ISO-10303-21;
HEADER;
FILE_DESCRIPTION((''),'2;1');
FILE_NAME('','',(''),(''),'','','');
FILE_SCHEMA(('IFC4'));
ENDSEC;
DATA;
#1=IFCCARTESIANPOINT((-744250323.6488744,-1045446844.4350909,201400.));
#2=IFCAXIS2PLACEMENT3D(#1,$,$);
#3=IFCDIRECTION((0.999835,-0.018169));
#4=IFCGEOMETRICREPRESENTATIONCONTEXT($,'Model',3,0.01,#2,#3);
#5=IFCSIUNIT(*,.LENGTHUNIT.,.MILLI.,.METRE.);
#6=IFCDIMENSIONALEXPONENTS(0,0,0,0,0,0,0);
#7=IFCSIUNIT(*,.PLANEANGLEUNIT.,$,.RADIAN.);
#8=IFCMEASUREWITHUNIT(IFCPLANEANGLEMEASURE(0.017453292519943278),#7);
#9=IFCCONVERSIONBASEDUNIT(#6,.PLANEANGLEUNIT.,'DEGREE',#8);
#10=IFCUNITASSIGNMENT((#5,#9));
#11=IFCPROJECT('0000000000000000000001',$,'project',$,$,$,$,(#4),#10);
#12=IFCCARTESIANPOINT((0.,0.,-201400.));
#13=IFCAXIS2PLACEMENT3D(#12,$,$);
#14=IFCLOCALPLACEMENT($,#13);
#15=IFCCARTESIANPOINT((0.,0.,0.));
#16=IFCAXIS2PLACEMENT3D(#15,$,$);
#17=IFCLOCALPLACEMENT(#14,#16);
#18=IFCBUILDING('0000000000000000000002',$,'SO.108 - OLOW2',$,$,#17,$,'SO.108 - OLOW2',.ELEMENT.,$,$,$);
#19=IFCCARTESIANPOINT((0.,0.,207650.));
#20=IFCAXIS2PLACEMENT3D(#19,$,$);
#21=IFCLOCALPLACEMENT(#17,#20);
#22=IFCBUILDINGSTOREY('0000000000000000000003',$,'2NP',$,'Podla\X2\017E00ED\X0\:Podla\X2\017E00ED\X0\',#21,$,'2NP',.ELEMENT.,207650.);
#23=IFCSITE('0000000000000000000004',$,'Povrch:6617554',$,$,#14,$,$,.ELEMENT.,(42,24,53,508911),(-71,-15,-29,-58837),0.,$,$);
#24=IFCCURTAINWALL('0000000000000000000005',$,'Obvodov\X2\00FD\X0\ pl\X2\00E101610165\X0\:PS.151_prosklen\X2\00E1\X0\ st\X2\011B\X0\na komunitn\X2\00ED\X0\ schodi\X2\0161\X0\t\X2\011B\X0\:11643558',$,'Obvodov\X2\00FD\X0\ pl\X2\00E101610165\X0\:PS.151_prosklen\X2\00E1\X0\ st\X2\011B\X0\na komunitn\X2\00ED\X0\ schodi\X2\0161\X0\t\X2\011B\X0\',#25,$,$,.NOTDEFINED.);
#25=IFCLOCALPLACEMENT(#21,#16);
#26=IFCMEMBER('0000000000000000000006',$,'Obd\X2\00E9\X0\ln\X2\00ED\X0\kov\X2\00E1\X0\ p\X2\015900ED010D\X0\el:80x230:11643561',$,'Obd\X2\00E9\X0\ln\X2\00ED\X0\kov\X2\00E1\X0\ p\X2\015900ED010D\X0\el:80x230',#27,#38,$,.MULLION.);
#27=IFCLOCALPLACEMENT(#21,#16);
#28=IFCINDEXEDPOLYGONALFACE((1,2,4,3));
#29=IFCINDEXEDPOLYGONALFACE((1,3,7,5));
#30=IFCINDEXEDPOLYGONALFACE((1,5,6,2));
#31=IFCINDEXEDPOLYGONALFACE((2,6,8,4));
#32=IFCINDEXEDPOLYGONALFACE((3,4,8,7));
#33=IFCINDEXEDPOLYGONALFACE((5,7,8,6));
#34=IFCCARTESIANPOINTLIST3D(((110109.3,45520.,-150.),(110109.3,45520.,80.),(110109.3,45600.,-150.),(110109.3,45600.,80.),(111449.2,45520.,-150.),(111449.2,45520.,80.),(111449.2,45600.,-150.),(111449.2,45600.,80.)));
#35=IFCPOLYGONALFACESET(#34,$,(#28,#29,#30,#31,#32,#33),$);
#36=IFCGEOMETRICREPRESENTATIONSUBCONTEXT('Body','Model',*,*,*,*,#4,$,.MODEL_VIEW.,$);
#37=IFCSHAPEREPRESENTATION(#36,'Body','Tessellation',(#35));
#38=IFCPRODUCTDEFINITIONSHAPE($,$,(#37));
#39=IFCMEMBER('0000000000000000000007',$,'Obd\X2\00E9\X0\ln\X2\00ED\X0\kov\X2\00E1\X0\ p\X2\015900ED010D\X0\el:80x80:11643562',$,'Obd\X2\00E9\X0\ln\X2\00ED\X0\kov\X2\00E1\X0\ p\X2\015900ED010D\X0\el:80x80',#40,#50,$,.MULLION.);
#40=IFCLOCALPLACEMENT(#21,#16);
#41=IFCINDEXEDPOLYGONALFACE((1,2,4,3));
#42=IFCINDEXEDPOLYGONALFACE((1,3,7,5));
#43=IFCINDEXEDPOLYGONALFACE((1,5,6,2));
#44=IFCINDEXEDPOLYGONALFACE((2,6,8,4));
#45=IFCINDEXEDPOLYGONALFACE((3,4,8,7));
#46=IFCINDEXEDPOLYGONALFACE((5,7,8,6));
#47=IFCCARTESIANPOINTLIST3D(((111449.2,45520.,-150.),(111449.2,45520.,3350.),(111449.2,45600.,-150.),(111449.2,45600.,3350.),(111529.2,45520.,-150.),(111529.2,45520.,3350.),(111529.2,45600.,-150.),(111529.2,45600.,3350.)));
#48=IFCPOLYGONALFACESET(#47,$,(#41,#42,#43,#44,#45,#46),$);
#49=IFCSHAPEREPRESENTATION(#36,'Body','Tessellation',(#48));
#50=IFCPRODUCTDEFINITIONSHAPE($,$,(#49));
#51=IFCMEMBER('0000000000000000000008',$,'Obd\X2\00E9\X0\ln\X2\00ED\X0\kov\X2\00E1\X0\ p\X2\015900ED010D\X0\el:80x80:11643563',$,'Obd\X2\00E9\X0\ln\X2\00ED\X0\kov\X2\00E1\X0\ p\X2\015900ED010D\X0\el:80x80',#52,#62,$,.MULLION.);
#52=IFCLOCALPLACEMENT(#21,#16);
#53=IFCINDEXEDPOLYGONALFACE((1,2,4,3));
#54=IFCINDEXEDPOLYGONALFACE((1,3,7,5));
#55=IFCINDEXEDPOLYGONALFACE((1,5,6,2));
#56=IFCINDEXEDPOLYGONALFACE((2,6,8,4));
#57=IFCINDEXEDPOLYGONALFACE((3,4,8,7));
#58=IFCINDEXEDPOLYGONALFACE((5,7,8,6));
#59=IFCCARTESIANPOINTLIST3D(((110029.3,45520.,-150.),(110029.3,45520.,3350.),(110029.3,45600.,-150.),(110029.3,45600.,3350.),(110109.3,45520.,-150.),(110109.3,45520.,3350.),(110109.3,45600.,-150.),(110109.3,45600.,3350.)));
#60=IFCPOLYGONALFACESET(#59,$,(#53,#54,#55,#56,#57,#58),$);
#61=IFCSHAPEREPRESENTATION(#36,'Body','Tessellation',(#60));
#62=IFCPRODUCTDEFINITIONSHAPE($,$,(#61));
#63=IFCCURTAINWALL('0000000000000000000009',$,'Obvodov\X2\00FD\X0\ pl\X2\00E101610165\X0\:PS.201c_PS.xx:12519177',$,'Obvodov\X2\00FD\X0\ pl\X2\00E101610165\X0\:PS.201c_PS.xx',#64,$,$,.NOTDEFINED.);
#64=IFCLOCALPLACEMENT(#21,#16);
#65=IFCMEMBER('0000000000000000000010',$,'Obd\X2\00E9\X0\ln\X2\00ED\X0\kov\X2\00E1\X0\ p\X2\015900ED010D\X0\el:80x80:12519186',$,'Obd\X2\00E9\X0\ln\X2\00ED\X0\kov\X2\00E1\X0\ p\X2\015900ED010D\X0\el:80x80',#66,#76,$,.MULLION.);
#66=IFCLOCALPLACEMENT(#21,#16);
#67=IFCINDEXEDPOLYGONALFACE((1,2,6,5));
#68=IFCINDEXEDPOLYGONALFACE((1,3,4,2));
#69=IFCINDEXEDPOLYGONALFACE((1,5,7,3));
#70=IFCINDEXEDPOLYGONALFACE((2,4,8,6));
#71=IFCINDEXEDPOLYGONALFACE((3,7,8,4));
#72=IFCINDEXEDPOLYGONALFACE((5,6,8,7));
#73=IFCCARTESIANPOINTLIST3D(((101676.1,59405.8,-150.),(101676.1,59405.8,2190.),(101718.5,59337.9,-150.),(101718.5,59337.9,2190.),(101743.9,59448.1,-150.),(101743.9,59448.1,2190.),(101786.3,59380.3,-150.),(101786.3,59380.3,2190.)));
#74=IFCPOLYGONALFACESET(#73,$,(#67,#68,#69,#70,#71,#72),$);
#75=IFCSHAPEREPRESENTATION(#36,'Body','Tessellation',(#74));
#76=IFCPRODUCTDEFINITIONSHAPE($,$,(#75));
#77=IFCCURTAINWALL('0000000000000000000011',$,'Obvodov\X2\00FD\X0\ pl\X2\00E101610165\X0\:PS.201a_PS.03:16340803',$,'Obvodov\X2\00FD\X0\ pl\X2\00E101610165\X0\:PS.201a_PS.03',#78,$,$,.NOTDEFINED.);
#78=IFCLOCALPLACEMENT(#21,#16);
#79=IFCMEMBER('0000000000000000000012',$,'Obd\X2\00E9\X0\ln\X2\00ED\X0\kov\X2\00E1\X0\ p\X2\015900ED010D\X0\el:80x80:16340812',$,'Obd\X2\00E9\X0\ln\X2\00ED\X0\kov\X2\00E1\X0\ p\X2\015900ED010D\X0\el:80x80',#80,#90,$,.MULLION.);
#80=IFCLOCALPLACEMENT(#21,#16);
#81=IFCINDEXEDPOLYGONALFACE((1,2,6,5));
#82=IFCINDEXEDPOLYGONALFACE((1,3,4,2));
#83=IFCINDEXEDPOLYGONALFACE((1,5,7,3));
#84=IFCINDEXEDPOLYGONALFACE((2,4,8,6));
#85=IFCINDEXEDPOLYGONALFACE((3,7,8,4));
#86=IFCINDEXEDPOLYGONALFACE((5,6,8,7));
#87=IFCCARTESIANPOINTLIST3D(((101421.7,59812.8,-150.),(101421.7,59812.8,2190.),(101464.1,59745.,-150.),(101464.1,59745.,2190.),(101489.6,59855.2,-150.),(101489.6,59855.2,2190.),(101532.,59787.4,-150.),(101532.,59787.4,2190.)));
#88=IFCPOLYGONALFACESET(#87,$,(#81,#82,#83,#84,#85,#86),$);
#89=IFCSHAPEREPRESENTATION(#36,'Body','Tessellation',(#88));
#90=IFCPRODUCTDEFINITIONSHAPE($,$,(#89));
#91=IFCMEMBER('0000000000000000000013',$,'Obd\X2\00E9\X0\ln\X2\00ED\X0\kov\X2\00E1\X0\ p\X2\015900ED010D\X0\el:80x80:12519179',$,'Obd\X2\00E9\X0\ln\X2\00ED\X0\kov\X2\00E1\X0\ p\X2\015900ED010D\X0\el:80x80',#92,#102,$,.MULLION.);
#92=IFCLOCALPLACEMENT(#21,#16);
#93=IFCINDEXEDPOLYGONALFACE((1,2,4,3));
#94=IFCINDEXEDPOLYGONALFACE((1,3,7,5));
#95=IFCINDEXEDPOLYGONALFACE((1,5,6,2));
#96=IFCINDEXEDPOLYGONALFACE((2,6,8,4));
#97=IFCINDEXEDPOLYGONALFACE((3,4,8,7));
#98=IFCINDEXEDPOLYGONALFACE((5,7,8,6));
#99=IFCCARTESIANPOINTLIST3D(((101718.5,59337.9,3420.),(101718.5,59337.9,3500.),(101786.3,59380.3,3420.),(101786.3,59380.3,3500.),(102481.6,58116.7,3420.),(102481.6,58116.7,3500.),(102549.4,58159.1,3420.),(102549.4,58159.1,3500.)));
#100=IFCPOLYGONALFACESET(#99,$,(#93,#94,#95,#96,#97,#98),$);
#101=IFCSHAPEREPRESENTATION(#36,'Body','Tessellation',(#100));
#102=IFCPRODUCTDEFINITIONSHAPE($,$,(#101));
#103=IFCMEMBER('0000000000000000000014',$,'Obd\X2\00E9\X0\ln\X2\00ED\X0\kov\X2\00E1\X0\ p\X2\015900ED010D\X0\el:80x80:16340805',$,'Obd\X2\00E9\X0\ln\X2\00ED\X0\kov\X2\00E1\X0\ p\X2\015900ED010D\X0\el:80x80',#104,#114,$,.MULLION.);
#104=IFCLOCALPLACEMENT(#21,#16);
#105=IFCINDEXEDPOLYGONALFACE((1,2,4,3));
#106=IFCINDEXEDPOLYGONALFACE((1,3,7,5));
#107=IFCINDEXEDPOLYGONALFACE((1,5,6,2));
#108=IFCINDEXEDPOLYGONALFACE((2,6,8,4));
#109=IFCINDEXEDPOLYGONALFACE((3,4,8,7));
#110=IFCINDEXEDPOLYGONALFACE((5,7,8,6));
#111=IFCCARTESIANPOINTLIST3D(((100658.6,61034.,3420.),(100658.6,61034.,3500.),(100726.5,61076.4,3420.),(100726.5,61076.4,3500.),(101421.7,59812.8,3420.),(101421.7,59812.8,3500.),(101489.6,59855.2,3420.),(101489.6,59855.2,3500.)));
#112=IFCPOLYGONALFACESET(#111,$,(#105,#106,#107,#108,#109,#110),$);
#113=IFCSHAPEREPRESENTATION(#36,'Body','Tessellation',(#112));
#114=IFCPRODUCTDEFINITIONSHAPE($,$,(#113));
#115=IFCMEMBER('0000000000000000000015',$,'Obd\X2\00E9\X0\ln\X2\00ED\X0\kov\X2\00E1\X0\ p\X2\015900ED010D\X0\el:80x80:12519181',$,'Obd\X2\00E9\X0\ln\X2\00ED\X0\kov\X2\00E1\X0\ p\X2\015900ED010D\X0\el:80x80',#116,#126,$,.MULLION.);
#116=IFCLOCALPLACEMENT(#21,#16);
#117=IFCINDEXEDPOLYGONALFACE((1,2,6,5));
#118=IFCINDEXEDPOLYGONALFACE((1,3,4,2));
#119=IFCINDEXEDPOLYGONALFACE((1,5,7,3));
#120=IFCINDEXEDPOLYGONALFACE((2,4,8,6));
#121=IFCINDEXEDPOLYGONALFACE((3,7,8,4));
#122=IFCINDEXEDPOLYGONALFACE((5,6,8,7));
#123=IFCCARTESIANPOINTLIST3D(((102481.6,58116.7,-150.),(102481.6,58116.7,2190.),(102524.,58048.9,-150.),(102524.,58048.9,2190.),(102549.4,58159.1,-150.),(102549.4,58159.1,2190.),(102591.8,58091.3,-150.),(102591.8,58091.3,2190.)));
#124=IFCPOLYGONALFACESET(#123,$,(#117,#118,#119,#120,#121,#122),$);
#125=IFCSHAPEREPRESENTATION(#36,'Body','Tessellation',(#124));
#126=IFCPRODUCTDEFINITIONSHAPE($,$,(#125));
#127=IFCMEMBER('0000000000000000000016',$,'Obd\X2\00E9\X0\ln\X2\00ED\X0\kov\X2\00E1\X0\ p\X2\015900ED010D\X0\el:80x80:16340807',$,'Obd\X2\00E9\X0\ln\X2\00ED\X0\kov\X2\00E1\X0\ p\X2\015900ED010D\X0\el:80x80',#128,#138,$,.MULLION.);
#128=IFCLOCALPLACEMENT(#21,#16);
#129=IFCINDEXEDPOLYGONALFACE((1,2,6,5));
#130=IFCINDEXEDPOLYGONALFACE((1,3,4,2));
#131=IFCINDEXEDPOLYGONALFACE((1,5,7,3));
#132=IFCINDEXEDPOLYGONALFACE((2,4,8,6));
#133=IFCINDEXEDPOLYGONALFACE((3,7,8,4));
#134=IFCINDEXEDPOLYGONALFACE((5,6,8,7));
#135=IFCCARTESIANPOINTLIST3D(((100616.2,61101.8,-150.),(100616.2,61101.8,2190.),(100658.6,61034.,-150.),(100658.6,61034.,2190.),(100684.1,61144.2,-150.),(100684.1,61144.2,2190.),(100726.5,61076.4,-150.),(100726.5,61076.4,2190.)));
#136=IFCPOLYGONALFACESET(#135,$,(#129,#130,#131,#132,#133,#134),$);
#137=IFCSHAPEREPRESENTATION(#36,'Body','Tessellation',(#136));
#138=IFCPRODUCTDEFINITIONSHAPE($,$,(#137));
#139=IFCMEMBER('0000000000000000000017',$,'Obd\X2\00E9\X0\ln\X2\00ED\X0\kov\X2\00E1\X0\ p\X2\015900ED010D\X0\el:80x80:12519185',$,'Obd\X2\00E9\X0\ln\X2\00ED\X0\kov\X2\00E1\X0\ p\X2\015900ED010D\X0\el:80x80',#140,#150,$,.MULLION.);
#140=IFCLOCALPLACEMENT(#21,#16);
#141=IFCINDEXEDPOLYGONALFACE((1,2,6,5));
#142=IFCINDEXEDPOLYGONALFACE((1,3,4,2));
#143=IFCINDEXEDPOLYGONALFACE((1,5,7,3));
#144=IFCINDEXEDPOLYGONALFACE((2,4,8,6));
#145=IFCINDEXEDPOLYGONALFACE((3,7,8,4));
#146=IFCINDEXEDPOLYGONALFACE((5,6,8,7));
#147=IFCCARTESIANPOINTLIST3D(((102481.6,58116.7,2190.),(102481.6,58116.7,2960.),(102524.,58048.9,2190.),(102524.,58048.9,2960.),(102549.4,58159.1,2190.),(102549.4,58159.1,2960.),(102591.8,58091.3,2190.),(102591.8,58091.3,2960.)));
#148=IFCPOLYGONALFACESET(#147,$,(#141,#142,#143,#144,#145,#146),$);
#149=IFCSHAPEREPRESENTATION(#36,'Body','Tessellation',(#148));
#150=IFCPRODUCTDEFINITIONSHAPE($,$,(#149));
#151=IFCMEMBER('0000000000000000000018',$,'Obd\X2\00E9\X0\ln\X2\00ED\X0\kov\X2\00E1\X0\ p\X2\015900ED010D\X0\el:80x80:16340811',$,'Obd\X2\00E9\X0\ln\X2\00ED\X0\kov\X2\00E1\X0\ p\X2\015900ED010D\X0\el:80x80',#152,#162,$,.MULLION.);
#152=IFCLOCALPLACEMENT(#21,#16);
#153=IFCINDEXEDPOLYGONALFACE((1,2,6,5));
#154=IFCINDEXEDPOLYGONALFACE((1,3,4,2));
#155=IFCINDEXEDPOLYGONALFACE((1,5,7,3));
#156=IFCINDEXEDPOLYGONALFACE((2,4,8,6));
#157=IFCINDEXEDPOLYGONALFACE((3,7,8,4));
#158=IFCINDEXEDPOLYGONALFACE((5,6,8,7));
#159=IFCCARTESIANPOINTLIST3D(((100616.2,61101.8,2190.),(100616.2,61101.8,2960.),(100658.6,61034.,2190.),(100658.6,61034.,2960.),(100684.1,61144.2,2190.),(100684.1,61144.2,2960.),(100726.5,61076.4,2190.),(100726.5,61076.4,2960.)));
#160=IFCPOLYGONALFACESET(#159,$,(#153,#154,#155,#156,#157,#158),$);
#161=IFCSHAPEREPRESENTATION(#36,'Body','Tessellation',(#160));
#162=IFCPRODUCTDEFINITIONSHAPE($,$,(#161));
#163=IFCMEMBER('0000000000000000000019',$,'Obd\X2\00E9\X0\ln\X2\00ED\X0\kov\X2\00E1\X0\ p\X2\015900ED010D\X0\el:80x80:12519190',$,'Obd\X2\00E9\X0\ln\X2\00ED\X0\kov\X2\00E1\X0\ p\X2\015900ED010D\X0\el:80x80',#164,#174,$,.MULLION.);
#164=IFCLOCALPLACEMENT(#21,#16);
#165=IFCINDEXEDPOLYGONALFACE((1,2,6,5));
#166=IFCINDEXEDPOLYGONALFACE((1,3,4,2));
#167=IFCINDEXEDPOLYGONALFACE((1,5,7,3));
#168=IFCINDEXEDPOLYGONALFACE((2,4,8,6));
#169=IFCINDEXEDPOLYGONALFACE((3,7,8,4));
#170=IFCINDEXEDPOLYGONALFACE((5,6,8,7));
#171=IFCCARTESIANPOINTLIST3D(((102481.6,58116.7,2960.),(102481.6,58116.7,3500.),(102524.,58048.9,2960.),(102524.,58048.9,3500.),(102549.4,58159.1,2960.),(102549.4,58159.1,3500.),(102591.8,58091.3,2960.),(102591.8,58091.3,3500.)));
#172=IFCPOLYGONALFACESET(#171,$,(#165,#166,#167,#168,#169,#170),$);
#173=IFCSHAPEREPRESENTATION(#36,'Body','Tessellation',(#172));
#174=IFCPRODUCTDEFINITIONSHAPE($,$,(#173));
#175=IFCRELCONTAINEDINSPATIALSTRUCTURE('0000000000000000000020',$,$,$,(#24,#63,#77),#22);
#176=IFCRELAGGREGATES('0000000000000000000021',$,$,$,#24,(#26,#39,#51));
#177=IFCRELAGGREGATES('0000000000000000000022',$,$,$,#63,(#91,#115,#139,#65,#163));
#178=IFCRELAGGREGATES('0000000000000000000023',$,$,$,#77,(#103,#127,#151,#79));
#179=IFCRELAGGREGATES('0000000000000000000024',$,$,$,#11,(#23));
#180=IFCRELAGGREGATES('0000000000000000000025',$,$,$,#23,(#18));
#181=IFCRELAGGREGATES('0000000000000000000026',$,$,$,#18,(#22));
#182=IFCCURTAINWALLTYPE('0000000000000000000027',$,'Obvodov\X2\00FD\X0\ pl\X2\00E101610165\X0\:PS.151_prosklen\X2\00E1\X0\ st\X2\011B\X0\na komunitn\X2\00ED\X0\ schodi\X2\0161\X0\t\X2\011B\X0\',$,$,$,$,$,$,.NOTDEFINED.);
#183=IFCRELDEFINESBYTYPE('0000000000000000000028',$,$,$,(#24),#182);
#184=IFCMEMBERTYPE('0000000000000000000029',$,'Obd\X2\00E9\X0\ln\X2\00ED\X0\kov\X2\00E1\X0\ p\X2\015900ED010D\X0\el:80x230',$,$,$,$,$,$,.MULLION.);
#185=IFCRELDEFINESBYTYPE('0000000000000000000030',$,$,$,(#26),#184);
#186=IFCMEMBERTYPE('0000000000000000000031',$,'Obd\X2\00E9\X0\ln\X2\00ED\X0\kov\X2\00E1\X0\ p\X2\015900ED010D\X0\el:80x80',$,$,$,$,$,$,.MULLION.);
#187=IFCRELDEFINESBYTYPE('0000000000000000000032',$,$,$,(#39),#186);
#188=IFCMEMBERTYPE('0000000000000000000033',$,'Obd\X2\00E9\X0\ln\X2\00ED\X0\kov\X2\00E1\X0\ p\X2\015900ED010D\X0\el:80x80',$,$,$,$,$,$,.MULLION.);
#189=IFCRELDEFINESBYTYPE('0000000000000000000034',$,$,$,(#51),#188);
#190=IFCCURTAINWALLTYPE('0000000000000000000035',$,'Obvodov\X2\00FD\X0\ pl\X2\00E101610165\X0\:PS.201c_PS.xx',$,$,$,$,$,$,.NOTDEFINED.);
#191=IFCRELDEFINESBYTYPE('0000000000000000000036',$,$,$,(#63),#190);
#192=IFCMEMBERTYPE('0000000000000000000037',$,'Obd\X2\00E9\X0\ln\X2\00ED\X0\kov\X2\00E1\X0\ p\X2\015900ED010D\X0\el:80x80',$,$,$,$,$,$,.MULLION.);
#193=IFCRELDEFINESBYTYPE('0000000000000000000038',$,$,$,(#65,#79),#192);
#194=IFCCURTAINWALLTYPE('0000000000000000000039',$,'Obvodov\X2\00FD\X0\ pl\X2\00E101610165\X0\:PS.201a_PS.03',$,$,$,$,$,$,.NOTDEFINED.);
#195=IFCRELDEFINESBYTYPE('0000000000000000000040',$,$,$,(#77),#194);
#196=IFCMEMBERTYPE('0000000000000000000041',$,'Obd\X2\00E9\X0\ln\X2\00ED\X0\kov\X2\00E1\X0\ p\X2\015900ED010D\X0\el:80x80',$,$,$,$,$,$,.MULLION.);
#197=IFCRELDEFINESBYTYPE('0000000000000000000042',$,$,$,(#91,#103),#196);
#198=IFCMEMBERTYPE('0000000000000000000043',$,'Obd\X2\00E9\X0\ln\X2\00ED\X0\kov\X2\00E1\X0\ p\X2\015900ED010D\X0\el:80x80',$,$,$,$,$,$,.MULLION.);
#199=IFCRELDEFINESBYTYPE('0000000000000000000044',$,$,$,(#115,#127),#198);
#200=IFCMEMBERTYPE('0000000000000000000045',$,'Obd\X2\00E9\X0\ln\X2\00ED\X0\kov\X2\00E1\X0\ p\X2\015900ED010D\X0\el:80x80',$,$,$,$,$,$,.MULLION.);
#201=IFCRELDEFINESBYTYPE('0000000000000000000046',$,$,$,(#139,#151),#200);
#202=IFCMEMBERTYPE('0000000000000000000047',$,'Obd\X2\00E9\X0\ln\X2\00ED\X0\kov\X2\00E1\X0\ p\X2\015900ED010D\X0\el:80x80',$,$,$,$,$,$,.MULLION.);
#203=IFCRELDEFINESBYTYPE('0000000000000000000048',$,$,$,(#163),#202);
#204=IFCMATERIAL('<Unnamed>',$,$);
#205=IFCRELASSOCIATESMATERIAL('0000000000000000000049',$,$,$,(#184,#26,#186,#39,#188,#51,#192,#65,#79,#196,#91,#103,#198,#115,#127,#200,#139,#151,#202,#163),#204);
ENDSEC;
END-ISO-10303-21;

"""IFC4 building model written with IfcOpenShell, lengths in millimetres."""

from ifc_helpers import new_model, entity, si_unit, converted_unit, direction, frame, origin, place, context, subcontext, project, spatial, indexed_curve, outline, extrude, source, transform, mapped, material, type_object, type_shapes, element, aggregate, save


model = new_model("IFC4")

# Units and contexts
model_context = context("Model", 3, precision=0.01, world=frame((-744250323.6488744, -1045446844.4350909, 201400.0)), true_north=direction((0.999835, -0.018169)))
body_context = subcontext(model_context, "Body", "Model", "MODEL_VIEW")
ifc_project = project(units=[si_unit("LENGTHUNIT", "METRE", prefix="MILLI"), converted_unit("PLANEANGLEUNIT", "DEGREE", entity("IfcPlaneAngleMeasure", 0.017453292519943278), si_unit("PLANEANGLEUNIT", "RADIAN"), dimensions=[0, 0, 0, 0, 0, 0, 0])], contexts=[model_context])

# Site, building, storey
site_placement = place(None, frame((0.0, 0.0, -201400.0)))
site = spatial("IfcSite", under=ifc_project, at=site_placement, Name="Povrch:6617554", CompositionType="ELEMENT", RefLatitude=(42, 24, 53, 508911), RefLongitude=(-71, -15, -29, -58837), RefElevation=0.0)
building_placement = place(site_placement, origin())
building = spatial("IfcBuilding", under=site, at=building_placement, Name="SO.108 - OLOW2", LongName="SO.108 - OLOW2", CompositionType="ELEMENT")
storey_placement = place(building_placement, frame((0.0, 0.0, 207650.0)))
storey = spatial("IfcBuildingStorey", under=building, at=storey_placement, Name="2NP", ObjectType="Podlaží:Podlaží", LongName="2NP", CompositionType="ELEMENT", Elevation=207650.0)

# Curtain wall, members
curtain_wall_type_1 = type_object("IfcCurtainWallType", Name="Obvodový plášť:PS.151_prosklená stěna komunitní schodiště", PredefinedType="NOTDEFINED")
curtain_wall_1_placement = place(storey_placement, frame((0.0, 0.0, -207650.0)))
curtain_wall_1 = element("IfcCurtainWall", 1, at=curtain_wall_1_placement, inside=storey, type_object=curtain_wall_type_1, Name="Obvodový plášť:PS.151_prosklená stěna komunitní schodiště:11643558", ObjectType="Obvodový plášť:PS.151_prosklená stěna komunitní schodiště", PredefinedType="NOTDEFINED")
ifc_material_1 = material(Name="<Unnamed>")
member_type_1 = type_object("IfcMemberType", Name="Obdélníková příčel:80x230", PredefinedType="MULLION", material=ifc_material_1)
shared_shape_1 = source(origin(), body_context, "Body", "SweptSolid", [
    extrude(outline(indexed_curve([(-115.0, -40.0), (115.0, -40.0), (115.0, 40.0), (-115.0, 40.0), (-115.0, -40.0)], self_intersect=False)), frame((-115.0, 0.0, -1339.9), z_axis=(0.0, 0.0, 1.0), x_axis=(-1.0, 0.0, 0.0)), (0.0, 0.0, 1.0), 1339.9),
])
type_shapes(member_type_1, [shared_shape_1])
member_1_placement = place(curtain_wall_1_placement, frame((110109.3, 45560.0, 207500.0), z_axis=(-1.0, 0.0, 0.0), x_axis=(0.0, 0.0, -1.0)))
member_1 = element("IfcMember", 2, at=member_1_placement, type_object=member_type_1, material=ifc_material_1, Name="Obdélníková příčel:80x230:11643561", ObjectType="Obdélníková příčel:80x230", PredefinedType="MULLION", context=body_context, shape_type="MappedRepresentation", body=[
    mapped(shared_shape_1, transform((0.0, 0.0, 0.0), scale=1.0)),
])
member_type_2 = type_object("IfcMemberType", Name="Obdélníková příčel:80x80", PredefinedType="MULLION", material=ifc_material_1)
shared_shape_2 = source(origin(), body_context, "Body", "SweptSolid", [
    extrude(outline(indexed_curve([(-40.0, -40.0), (40.0, -40.0), (40.0, 40.0), (-40.0, 40.0), (-40.0, -40.0)], self_intersect=False)), frame((-40.0, 0.0, -3500.0), z_axis=(0.0, 0.0, 1.0), x_axis=(-1.0, 0.0, 0.0)), (0.0, 0.0, 1.0), 3500.0),
])
type_shapes(member_type_2, [shared_shape_2])
member_2_placement = place(curtain_wall_1_placement, frame((111529.2, 45560.0, 207500.0), z_axis=(0.0, 0.0, -1.0), x_axis=(1.0, 0.0, 0.0)))
member_2 = element("IfcMember", 3, at=member_2_placement, type_object=member_type_2, material=ifc_material_1, Name="Obdélníková příčel:80x80:11643562", ObjectType="Obdélníková příčel:80x80", PredefinedType="MULLION", context=body_context, shape_type="MappedRepresentation", body=[
    mapped(shared_shape_2, transform((0.0, 0.0, 0.0), scale=1.0)),
])
member_type_3 = type_object("IfcMemberType", Name="Obdélníková příčel:80x80", PredefinedType="MULLION", material=ifc_material_1)
shared_shape_3 = source(origin(), body_context, "Body", "SweptSolid", [
    extrude(outline(indexed_curve([(-40.0, -40.0), (40.0, -40.0), (40.0, 40.0), (-40.0, 40.0), (-40.0, -40.0)], self_intersect=False)), frame((-40.0, 0.0, -3500.0), z_axis=(0.0, 0.0, 1.0), x_axis=(-1.0, 0.0, 0.0)), (0.0, 0.0, 1.0), 3500.0),
])
type_shapes(member_type_3, [shared_shape_3])
member_3_placement = place(curtain_wall_1_placement, frame((110029.3, 45560.0, 211000.0), z_axis=(0.0, 0.0, 1.0), x_axis=(-1.0, 0.0, 0.0)))
member_3 = element("IfcMember", 4, at=member_3_placement, type_object=member_type_3, material=ifc_material_1, Name="Obdélníková příčel:80x80:11643563", ObjectType="Obdélníková příčel:80x80", PredefinedType="MULLION", context=body_context, shape_type="MappedRepresentation", body=[
    mapped(shared_shape_3, transform((0.0, 0.0, 0.0), scale=1.0)),
])
aggregate(curtain_wall_1, [member_1, member_2, member_3])

# Curtain walls, members
curtain_wall_type_2 = type_object("IfcCurtainWallType", Name="Obvodový plášť:PS.201c_PS.xx", PredefinedType="NOTDEFINED")
curtain_wall_2_placement = place(storey_placement, frame((0.0, 0.0, -207650.0)))
curtain_wall_2 = element("IfcCurtainWall", 5, at=curtain_wall_2_placement, inside=storey, type_object=curtain_wall_type_2, Name="Obvodový plášť:PS.201c_PS.xx:12519177", ObjectType="Obvodový plášť:PS.201c_PS.xx", PredefinedType="NOTDEFINED")
member_type_4 = type_object("IfcMemberType", Name="Obdélníková příčel:80x80", PredefinedType="MULLION", material=ifc_material_1)
shared_shape_4 = source(origin(), body_context, "Body", "SweptSolid", [
    extrude(outline(indexed_curve([(-40.0, -40.0), (40.0, -40.0), (40.0, 40.0), (-40.0, 40.0), (-40.0, -40.0)], self_intersect=False)), frame((-40.0, 0.0, -2340.0), z_axis=(0.0, 0.0, 1.0), x_axis=(-1.0, 0.0, 0.0)), (0.0, 0.0, 1.0), 2340.0),
])
type_shapes(member_type_4, [shared_shape_4])
member_4_placement = place(curtain_wall_2_placement, frame((101710.0, 59426.9, 209840.0), z_axis=(0.0, 0.0, 1.0), x_axis=(-0.529919, 0.848048, 0.0)))
member_4 = element("IfcMember", 6, at=member_4_placement, type_object=member_type_4, material=ifc_material_1, Name="Obdélníková příčel:80x80:12519186", ObjectType="Obdélníková příčel:80x80", PredefinedType="MULLION", context=body_context, shape_type="MappedRepresentation", body=[
    mapped(shared_shape_4, transform((0.0, 0.0, 0.0), scale=1.0)),
])
curtain_wall_type_3 = type_object("IfcCurtainWallType", Name="Obvodový plášť:PS.201a_PS.03", PredefinedType="NOTDEFINED")
curtain_wall_3_placement = place(storey_placement, frame((0.0, 0.0, -207650.0)))
curtain_wall_3 = element("IfcCurtainWall", 7, at=curtain_wall_3_placement, inside=storey, type_object=curtain_wall_type_3, Name="Obvodový plášť:PS.201a_PS.03:16340803", ObjectType="Obvodový plášť:PS.201a_PS.03", PredefinedType="NOTDEFINED")
member_5_placement = place(curtain_wall_3_placement, frame((101498.0, 59766.2, 209840.0), z_axis=(0.0, 0.0, 1.0), x_axis=(0.529919, -0.848048, 0.0)))
member_5 = element("IfcMember", 8, at=member_5_placement, type_object=member_type_4, material=ifc_material_1, Name="Obdélníková příčel:80x80:16340812", ObjectType="Obdélníková příčel:80x80", PredefinedType="MULLION", context=body_context, shape_type="MappedRepresentation", body=[
    mapped(shared_shape_4, transform((0.0, 0.0, 0.0), scale=1.0)),
])

# Members
member_type_5 = type_object("IfcMemberType", Name="Obdélníková příčel:80x80", PredefinedType="MULLION", material=ifc_material_1)
shared_shape_5 = source(origin(), body_context, "Body", "SweptSolid", [
    extrude(outline(indexed_curve([(-40.0, -40.0), (40.0, -40.0), (40.0, 40.0), (-40.0, 40.0), (-40.0, -40.0)], self_intersect=False)), frame((-40.0, 0.0, -1440.0), z_axis=(0.0, 0.0, 1.0), x_axis=(-1.0, 0.0, 0.0)), (0.0, 0.0, 1.0), 1440.0),
])
type_shapes(member_type_5, [shared_shape_5])
member_6_placement = place(curtain_wall_2_placement, frame((102515.5, 58137.9, 211150.0), z_axis=(0.529919, -0.848048, 0.0), x_axis=(0.0, 0.0, 1.0)))
member_6 = element("IfcMember", 9, at=member_6_placement, type_object=member_type_5, material=ifc_material_1, Name="Obdélníková příčel:80x80:12519179", ObjectType="Obdélníková příčel:80x80", PredefinedType="MULLION", context=body_context, shape_type="MappedRepresentation", body=[
    mapped(shared_shape_5, transform((0.0, 0.0, 0.0), scale=1.0)),
])
member_7_placement = place(curtain_wall_3_placement, frame((100692.6, 61055.2, 211150.0), z_axis=(-0.529919, 0.848048, 0.0), x_axis=(0.0, 0.0, 1.0)))
member_7 = element("IfcMember", 10, at=member_7_placement, type_object=member_type_5, material=ifc_material_1, Name="Obdélníková příčel:80x80:16340805", ObjectType="Obdélníková příčel:80x80", PredefinedType="MULLION", context=body_context, shape_type="MappedRepresentation", body=[
    mapped(shared_shape_5, transform((0.0, 0.0, 0.0), scale=1.0)),
])
member_type_6 = type_object("IfcMemberType", Name="Obdélníková příčel:80x80", PredefinedType="MULLION", material=ifc_material_1)
shared_shape_6 = source(origin(), body_context, "Body", "SweptSolid", [
    extrude(outline(indexed_curve([(-40.0, -40.0), (40.0, -40.0), (40.0, 40.0), (-40.0, 40.0), (-40.0, -40.0)], self_intersect=False)), frame((-40.0, 0.0, -2340.0), z_axis=(0.0, 0.0, 1.0), x_axis=(-1.0, 0.0, 0.0)), (0.0, 0.0, 1.0), 2340.0),
])
type_shapes(member_type_6, [shared_shape_6])
member_8_placement = place(curtain_wall_2_placement, frame((102557.9, 58070.1, 207500.0), z_axis=(0.0, 0.0, -1.0), x_axis=(0.529919, -0.848048, 0.0)))
member_8 = element("IfcMember", 11, at=member_8_placement, type_object=member_type_6, material=ifc_material_1, Name="Obdélníková příčel:80x80:12519181", ObjectType="Obdélníková příčel:80x80", PredefinedType="MULLION", context=body_context, shape_type="MappedRepresentation", body=[
    mapped(shared_shape_6, transform((0.0, 0.0, 0.0), scale=1.0)),
])
member_9_placement = place(curtain_wall_3_placement, frame((100650.2, 61123.0, 207500.0), z_axis=(0.0, 0.0, -1.0), x_axis=(-0.529919, 0.848048, 0.0)))
member_9 = element("IfcMember", 12, at=member_9_placement, type_object=member_type_6, material=ifc_material_1, Name="Obdélníková příčel:80x80:16340807", ObjectType="Obdélníková příčel:80x80", PredefinedType="MULLION", context=body_context, shape_type="MappedRepresentation", body=[
    mapped(shared_shape_6, transform((0.0, 0.0, 0.0), scale=1.0)),
])
member_type_7 = type_object("IfcMemberType", Name="Obdélníková příčel:80x80", PredefinedType="MULLION", material=ifc_material_1)
shared_shape_7 = source(origin(), body_context, "Body", "SweptSolid", [
    extrude(outline(indexed_curve([(-40.0, -40.0), (40.0, -40.0), (40.0, 40.0), (-40.0, 40.0), (-40.0, -40.0)], self_intersect=False)), frame((-40.0, 0.0, -770.0), z_axis=(0.0, 0.0, 1.0), x_axis=(-1.0, 0.0, 0.0)), (0.0, 0.0, 1.0), 770.0),
])
type_shapes(member_type_7, [shared_shape_7])
member_10_placement = place(curtain_wall_2_placement, frame((102557.9, 58070.1, 209840.0), z_axis=(0.0, 0.0, -1.0), x_axis=(0.529919, -0.848048, 0.0)))
member_10 = element("IfcMember", 13, at=member_10_placement, type_object=member_type_7, material=ifc_material_1, Name="Obdélníková příčel:80x80:12519185", ObjectType="Obdélníková příčel:80x80", PredefinedType="MULLION", context=body_context, shape_type="MappedRepresentation", body=[
    mapped(shared_shape_7, transform((0.0, 0.0, 0.0), scale=1.0)),
])
member_11_placement = place(curtain_wall_3_placement, frame((100650.2, 61123.0, 209840.0), z_axis=(0.0, 0.0, -1.0), x_axis=(-0.529919, 0.848048, 0.0)))
member_11 = element("IfcMember", 14, at=member_11_placement, type_object=member_type_7, material=ifc_material_1, Name="Obdélníková příčel:80x80:16340811", ObjectType="Obdélníková příčel:80x80", PredefinedType="MULLION", context=body_context, shape_type="MappedRepresentation", body=[
    mapped(shared_shape_7, transform((0.0, 0.0, 0.0), scale=1.0)),
])
member_type_8 = type_object("IfcMemberType", Name="Obdélníková příčel:80x80", PredefinedType="MULLION", material=ifc_material_1)
shared_shape_8 = source(origin(), body_context, "Body", "SweptSolid", [
    extrude(outline(indexed_curve([(-40.0, -40.0), (40.0, -40.0), (40.0, 40.0), (-40.0, 40.0), (-40.0, -40.0)], self_intersect=False)), frame((-40.0, 0.0, -540.0), z_axis=(0.0, 0.0, 1.0), x_axis=(-1.0, 0.0, 0.0)), (0.0, 0.0, 1.0), 540.0),
])
type_shapes(member_type_8, [shared_shape_8])
member_12_placement = place(curtain_wall_2_placement, frame((102557.9, 58070.1, 210610.0), z_axis=(0.0, 0.0, -1.0), x_axis=(0.529919, -0.848048, 0.0)))
member_12 = element("IfcMember", 15, at=member_12_placement, type_object=member_type_8, material=ifc_material_1, Name="Obdélníková příčel:80x80:12519190", ObjectType="Obdélníková příčel:80x80", PredefinedType="MULLION", context=body_context, shape_type="MappedRepresentation", body=[
    mapped(shared_shape_8, transform((0.0, 0.0, 0.0), scale=1.0)),
])

aggregate(curtain_wall_2, [member_6, member_8, member_10, member_4, member_12])

aggregate(curtain_wall_3, [member_7, member_9, member_11, member_5])

save(model, "model.ifc")
